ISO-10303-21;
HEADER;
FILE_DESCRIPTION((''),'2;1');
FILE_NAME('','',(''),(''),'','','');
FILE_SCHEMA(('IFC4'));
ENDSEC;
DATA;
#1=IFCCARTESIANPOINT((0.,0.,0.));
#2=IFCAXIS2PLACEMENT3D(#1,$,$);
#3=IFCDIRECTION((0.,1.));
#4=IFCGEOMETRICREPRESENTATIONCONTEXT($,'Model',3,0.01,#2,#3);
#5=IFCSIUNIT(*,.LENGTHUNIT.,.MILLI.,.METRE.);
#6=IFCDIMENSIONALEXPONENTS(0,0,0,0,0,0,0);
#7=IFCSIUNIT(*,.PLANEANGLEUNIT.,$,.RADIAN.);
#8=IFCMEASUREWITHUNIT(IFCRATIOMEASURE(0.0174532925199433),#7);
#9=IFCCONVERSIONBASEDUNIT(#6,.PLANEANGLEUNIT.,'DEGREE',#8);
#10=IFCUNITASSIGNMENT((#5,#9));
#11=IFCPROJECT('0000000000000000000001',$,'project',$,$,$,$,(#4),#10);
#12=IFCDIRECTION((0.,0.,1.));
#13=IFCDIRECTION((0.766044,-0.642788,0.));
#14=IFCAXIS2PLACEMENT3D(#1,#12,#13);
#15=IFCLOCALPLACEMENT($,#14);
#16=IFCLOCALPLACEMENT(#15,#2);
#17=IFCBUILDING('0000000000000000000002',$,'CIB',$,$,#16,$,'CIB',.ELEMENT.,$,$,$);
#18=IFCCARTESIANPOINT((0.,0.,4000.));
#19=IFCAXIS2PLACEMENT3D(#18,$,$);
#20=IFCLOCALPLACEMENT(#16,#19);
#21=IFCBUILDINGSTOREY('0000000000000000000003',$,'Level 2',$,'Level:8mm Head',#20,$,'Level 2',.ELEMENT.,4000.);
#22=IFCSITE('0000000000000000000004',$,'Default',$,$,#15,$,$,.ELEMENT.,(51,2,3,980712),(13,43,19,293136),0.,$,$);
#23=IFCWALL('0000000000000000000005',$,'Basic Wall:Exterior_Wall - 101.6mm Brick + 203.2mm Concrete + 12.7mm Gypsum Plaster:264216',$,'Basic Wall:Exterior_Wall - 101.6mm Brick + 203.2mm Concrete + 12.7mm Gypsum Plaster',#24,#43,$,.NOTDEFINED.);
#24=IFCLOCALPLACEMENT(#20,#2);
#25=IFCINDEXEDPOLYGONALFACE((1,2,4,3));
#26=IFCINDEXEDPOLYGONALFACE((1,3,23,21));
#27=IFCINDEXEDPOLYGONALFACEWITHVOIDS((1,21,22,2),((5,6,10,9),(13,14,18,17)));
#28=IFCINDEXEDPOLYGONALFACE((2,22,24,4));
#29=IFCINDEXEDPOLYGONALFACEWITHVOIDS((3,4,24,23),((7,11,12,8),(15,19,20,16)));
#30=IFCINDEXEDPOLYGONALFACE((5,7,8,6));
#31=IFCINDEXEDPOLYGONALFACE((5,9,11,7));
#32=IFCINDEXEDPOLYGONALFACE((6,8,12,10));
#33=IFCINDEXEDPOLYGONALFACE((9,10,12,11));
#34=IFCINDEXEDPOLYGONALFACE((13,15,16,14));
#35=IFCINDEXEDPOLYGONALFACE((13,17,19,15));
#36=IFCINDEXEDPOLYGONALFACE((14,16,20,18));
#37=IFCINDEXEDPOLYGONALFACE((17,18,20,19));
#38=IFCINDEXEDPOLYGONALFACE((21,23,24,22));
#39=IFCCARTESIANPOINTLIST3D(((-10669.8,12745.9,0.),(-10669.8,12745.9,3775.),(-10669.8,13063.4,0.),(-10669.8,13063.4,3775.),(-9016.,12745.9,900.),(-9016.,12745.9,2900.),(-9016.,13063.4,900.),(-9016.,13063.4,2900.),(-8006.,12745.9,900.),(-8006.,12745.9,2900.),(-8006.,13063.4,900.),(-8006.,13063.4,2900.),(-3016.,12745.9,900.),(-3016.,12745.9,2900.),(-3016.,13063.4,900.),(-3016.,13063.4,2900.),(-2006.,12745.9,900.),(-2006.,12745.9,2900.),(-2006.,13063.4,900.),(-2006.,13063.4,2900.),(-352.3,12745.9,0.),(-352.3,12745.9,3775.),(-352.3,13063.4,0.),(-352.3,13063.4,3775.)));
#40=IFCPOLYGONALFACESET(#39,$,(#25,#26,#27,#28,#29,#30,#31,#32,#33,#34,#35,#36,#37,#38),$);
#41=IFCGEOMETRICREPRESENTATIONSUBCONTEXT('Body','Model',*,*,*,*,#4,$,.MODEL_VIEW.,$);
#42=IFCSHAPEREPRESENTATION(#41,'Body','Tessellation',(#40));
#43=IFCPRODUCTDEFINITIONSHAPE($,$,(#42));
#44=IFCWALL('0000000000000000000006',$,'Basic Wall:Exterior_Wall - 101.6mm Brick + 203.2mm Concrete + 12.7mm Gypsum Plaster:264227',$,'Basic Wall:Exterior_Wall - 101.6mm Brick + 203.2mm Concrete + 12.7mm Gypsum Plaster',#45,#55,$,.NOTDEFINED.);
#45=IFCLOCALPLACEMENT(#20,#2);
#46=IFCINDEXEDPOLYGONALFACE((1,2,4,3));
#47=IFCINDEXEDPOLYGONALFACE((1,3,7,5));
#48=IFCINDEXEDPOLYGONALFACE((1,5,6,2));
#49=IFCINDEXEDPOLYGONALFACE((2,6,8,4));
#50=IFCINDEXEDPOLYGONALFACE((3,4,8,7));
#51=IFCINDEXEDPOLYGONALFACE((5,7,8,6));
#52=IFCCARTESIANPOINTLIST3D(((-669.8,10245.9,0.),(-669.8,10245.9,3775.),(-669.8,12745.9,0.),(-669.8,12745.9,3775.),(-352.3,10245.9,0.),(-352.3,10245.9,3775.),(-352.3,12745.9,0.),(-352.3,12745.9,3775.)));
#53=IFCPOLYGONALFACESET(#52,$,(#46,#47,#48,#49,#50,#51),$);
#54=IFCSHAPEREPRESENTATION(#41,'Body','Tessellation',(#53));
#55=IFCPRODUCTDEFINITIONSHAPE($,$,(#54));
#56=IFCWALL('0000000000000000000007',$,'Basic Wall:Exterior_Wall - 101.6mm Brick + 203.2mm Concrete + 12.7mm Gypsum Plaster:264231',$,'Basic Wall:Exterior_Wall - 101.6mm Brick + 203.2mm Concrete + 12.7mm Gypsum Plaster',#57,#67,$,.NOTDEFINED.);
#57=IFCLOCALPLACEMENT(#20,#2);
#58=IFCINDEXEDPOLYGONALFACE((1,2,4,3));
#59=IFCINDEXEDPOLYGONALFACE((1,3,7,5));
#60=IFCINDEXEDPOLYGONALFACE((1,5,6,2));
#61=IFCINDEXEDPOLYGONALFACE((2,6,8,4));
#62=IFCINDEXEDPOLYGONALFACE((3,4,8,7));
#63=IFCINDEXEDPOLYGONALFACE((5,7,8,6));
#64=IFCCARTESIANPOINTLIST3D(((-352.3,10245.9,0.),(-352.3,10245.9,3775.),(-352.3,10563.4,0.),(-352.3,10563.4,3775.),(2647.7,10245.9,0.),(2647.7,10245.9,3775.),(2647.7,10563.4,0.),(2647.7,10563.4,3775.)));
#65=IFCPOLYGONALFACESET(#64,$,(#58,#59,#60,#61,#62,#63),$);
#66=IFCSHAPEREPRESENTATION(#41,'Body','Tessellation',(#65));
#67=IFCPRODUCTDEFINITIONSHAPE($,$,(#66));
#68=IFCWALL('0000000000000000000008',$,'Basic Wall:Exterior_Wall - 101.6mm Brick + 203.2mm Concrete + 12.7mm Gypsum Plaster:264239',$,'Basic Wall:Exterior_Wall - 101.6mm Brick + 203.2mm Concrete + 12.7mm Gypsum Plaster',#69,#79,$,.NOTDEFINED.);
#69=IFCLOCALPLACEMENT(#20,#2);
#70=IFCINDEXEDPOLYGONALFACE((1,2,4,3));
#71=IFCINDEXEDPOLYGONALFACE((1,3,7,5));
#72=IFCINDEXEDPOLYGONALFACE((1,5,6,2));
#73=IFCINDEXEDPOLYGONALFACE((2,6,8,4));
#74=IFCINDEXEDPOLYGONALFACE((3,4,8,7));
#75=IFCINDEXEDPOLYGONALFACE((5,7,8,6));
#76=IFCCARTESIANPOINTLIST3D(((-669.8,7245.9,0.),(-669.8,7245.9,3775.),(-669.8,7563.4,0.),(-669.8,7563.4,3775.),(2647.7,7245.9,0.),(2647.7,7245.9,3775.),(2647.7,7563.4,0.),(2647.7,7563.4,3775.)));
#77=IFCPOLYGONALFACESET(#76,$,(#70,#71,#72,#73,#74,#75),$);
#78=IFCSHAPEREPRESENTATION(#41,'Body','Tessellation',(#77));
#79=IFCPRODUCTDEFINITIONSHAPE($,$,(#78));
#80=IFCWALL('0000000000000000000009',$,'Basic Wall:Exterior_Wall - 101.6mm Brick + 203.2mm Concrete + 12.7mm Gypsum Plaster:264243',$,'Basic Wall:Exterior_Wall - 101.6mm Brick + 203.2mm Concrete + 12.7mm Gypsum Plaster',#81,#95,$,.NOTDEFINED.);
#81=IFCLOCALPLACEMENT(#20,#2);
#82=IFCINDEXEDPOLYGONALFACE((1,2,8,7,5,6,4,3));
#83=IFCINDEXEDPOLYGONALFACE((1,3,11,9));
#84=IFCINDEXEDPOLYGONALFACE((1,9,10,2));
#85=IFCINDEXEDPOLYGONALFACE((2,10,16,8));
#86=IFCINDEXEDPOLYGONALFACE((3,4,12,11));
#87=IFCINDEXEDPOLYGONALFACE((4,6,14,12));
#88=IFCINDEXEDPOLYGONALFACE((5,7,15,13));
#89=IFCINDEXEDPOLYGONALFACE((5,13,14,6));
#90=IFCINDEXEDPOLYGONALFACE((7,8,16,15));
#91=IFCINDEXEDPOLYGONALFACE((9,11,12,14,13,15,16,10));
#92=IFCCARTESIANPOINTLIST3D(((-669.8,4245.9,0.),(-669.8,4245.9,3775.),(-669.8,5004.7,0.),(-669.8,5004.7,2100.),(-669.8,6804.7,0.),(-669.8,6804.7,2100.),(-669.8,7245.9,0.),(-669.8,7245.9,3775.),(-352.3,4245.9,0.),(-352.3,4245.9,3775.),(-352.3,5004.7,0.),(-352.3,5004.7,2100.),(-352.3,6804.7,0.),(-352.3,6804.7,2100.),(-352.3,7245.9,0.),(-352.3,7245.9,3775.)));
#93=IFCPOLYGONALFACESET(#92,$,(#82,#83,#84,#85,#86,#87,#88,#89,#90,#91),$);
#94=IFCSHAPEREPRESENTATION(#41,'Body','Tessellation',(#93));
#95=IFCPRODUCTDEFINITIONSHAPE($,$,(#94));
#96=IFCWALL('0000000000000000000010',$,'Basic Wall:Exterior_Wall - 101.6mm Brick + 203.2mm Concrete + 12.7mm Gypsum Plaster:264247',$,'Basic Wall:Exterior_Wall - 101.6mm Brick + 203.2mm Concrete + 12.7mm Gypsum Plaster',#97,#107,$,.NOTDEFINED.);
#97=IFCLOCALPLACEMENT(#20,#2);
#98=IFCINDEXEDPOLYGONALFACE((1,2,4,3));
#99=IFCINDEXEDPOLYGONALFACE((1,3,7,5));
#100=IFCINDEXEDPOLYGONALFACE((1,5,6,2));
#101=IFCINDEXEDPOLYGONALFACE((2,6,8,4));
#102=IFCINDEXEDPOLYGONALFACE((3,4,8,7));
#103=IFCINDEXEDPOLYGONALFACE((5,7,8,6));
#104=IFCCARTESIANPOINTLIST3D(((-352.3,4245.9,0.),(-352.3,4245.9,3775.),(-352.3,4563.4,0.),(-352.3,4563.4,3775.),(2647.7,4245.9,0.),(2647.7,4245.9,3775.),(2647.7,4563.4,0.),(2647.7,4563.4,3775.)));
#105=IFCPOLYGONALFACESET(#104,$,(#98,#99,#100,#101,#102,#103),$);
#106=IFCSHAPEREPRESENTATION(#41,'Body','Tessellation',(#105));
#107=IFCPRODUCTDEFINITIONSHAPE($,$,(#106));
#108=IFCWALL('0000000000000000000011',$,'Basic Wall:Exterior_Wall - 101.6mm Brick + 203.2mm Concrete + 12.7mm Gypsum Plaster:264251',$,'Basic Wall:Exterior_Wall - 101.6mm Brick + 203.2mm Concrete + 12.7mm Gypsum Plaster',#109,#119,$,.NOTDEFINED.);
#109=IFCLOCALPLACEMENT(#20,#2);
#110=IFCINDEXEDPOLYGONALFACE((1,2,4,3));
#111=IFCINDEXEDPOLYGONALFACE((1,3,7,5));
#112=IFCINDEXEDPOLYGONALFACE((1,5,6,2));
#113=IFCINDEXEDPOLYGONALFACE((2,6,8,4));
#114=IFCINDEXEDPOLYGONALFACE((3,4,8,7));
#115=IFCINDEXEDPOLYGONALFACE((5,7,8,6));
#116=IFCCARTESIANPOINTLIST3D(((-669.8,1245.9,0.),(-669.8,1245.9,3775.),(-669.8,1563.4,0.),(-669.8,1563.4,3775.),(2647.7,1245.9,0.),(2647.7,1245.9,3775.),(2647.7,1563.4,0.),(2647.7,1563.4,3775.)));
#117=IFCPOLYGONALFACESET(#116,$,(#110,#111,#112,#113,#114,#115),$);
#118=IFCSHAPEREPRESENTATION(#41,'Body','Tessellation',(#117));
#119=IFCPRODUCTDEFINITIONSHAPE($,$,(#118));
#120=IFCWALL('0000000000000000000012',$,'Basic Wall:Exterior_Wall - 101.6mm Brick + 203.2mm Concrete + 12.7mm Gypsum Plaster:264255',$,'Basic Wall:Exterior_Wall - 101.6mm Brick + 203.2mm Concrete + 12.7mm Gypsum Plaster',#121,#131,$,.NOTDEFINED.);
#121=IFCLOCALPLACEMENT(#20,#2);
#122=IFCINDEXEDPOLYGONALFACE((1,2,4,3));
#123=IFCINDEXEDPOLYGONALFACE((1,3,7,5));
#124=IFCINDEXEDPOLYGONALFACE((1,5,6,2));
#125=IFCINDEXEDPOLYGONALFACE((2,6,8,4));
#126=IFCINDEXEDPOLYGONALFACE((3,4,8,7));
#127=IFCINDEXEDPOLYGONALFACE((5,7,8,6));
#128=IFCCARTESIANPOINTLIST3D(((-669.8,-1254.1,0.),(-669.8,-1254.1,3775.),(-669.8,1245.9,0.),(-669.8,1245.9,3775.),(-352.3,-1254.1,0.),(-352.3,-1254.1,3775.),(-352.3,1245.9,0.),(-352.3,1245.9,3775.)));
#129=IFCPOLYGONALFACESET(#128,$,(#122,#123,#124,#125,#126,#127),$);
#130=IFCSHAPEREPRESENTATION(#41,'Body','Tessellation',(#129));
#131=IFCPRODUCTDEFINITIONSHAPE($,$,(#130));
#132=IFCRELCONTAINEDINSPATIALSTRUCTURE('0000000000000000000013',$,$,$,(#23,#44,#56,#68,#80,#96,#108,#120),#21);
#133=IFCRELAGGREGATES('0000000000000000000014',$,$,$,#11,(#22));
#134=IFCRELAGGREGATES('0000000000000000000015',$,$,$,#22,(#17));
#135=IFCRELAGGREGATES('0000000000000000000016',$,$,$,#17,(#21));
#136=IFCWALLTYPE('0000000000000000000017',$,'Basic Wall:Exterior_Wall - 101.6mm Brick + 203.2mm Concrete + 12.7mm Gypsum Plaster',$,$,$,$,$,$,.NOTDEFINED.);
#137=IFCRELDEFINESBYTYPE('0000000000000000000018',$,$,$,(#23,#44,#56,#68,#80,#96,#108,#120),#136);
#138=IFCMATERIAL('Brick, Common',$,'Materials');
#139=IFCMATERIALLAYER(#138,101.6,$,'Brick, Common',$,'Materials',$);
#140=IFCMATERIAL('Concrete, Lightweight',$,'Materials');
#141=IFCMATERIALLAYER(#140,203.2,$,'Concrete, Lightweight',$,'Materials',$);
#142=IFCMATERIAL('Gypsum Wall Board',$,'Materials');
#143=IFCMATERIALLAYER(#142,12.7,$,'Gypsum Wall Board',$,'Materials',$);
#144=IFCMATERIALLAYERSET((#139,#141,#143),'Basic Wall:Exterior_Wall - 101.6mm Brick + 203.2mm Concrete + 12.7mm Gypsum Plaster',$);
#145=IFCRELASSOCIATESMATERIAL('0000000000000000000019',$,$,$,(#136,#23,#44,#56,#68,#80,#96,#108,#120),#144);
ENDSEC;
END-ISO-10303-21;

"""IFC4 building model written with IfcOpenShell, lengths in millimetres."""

from ifc_helpers import new_model, entity, si_unit, converted_unit, direction, frame, frame_2d, origin, place, context, subcontext, project, spatial, polyline, rectangle, extrude, clip, bounded_halfspace, material, layer, layer_set, layer_usage, type_object, element, save


model = new_model("IFC4")

# Units and contexts
model_context = context("Model", 3, precision=0.01, world=origin(), true_north=direction((0.0, 1.0)))
body_context = subcontext(model_context, "Body", "Model", "MODEL_VIEW")
ifc_project = project(units=[si_unit("LENGTHUNIT", "METRE", prefix="MILLI"), converted_unit("PLANEANGLEUNIT", "DEGREE", entity("IfcRatioMeasure", 0.0174532925199433), si_unit("PLANEANGLEUNIT", "RADIAN"), dimensions=[0, 0, 0, 0, 0, 0, 0])], contexts=[model_context])

# Site, building, storey
site_placement = place(None, frame((0.0, 0.0, 0.0), z_axis=(0.0, 0.0, 1.0), x_axis=(0.766044, -0.642788, 0.0)))
site = spatial("IfcSite", under=ifc_project, at=site_placement, Name="Default", CompositionType="ELEMENT", RefLatitude=(51, 2, 3, 980712), RefLongitude=(13, 43, 19, 293136), RefElevation=0.0)
building_placement = place(site_placement, origin())
building = spatial("IfcBuilding", under=site, at=building_placement, Name="CIB", LongName="CIB", CompositionType="ELEMENT")
storey_placement = place(building_placement, frame((0.0, 0.0, 4000.0)))
storey = spatial("IfcBuildingStorey", under=building, at=storey_placement, Name="Level 2", ObjectType="Level:8mm Head", LongName="Level 2", CompositionType="ELEMENT", Elevation=4000.0)

# Wall, openings
ifc_material_1 = material(Name="Brick, Common", Category="Materials")
ifc_layer_1 = layer(ifc_material_1, 101.6, Name="Brick, Common", Category="Materials")
ifc_material_2 = material(Name="Concrete, Lightweight", Category="Materials")
ifc_layer_2 = layer(ifc_material_2, 203.2, Name="Concrete, Lightweight", Category="Materials")
ifc_material_3 = material(Name="Gypsum Wall Board", Category="Materials")
ifc_layer_3 = layer(ifc_material_3, 12.7, Name="Gypsum Wall Board", Category="Materials")
ifc_layer_set_1 = layer_set([ifc_layer_1, ifc_layer_2, ifc_layer_3], Name="Basic Wall:Exterior_Wall - 101.6mm Brick + 203.2mm Concrete + 12.7mm Gypsum Plaster")
ifc_layer_usage_1 = layer_usage(ifc_layer_set_1, "AXIS2", "POSITIVE", -158.8)
wall_type_1 = type_object("IfcWallType", Name="Basic Wall:Exterior_Wall - 101.6mm Brick + 203.2mm Concrete + 12.7mm Gypsum Plaster", PredefinedType="NOTDEFINED", material=ifc_layer_set_1)
wall_1_placement = place(storey_placement, frame((-352.3, 12904.7, 0.0), z_axis=(0.0, 0.0, 1.0), x_axis=(-1.0, 0.0, 0.0)))
wall_1 = element("IfcWall", 1, at=wall_1_placement, inside=storey, type_object=wall_type_1, material=ifc_layer_usage_1, Name="Basic Wall:Exterior_Wall - 101.6mm Brick + 203.2mm Concrete + 12.7mm Gypsum Plaster:264216", ObjectType="Basic Wall:Exterior_Wall - 101.6mm Brick + 203.2mm Concrete + 12.7mm Gypsum Plaster", PredefinedType="NOTDEFINED", context=body_context, shape_type="Clipping", body=[
    clip(extrude(rectangle(XDim=10317.5, YDim=317.5, at=frame_2d((5158.7, 0.0), x_axis=(-1.0, 0.0))), origin(), (0.0, 0.0, 1.0), 3775.0), bounded_halfspace(frame((0.0, -158.7, 3775.0), z_axis=(0.0, 0.0, -1.0), x_axis=(0.0, -1.0, 0.0)), True, frame((0.0, -158.7, 3775.0)), polyline([(0.0, 0.0), (10317.5, 0.0), (10317.5, 317.5), (10000.0, 317.5), (317.5, 317.5), (0.0, 317.5), (0.0, 0.0)]))),
])
opening_1_placement = place(wall_1_placement, frame((1653.7, -158.7, 900.0)))
element("IfcOpeningElement", 2, at=opening_1_placement, cuts=wall_1, ObjectType="Opening", PredefinedType="OPENING", context=body_context, shape_type="SweptSolid", body=[
    extrude(rectangle(XDim=2000.0, YDim=1010.0, at=frame_2d((1000.0, 505.0), x_axis=(1.0, 0.0))), frame((0.0, 0.0, 0.0), z_axis=(0.0, 1.0, 0.0), x_axis=(0.0, 0.0, 1.0)), (0.0, 0.0, 1.0), 317.5),
])
opening_2_placement = place(wall_1_placement, frame((7653.7, -158.7, 900.0)))
element("IfcOpeningElement", 3, at=opening_2_placement, cuts=wall_1, ObjectType="Opening", PredefinedType="OPENING", context=body_context, shape_type="SweptSolid", body=[
    extrude(rectangle(XDim=2000.0, YDim=1010.0, at=frame_2d((1000.0, 505.0), x_axis=(1.0, 0.0))), frame((0.0, 0.0, 0.0), z_axis=(0.0, 1.0, 0.0), x_axis=(0.0, 0.0, 1.0)), (0.0, 0.0, 1.0), 317.5),
])

# Walls
ifc_layer_usage_2 = layer_usage(ifc_layer_set_1, "AXIS2", "NEGATIVE", 158.8)
wall_2_placement = place(storey_placement, frame((-511.0, 12745.9, 0.0), z_axis=(0.0, 0.0, 1.0), x_axis=(0.0, -1.0, 0.0)))
element("IfcWall", 4, at=wall_2_placement, inside=storey, type_object=wall_type_1, material=ifc_layer_usage_2, Name="Basic Wall:Exterior_Wall - 101.6mm Brick + 203.2mm Concrete + 12.7mm Gypsum Plaster:264227", ObjectType="Basic Wall:Exterior_Wall - 101.6mm Brick + 203.2mm Concrete + 12.7mm Gypsum Plaster", PredefinedType="NOTDEFINED", context=body_context, shape_type="Clipping", body=[
    clip(extrude(rectangle(XDim=2500.0, YDim=317.5, at=frame_2d((1250.0, 0.0), x_axis=(-1.0, 0.0))), origin(), (0.0, 0.0, 1.0), 3775.0), bounded_halfspace(frame((0.0, -158.8, 3775.0), z_axis=(0.0, 0.0, -1.0), x_axis=(-1.0, 0.0, 0.0)), True, frame((0.0, -158.8, 3775.0)), polyline([(0.0, 0.0), (2500.0, 0.0), (2500.0, 317.5), (2182.5, 317.5), (0.0, 317.5), (0.0, 0.0)]))),
])
ifc_layer_usage_3 = layer_usage(ifc_layer_set_1, "AXIS2", "NEGATIVE", 158.8)
wall_3_placement = place(storey_placement, frame((-352.3, 10404.7, 0.0)))
element("IfcWall", 5, at=wall_3_placement, inside=storey, type_object=wall_type_1, material=ifc_layer_usage_3, Name="Basic Wall:Exterior_Wall - 101.6mm Brick + 203.2mm Concrete + 12.7mm Gypsum Plaster:264231", ObjectType="Basic Wall:Exterior_Wall - 101.6mm Brick + 203.2mm Concrete + 12.7mm Gypsum Plaster", PredefinedType="NOTDEFINED", context=body_context, shape_type="Clipping", body=[
    clip(extrude(rectangle(XDim=3000.0, YDim=317.5, at=frame_2d((1500.0, 0.0), x_axis=(-1.0, 0.0))), origin(), (0.0, 0.0, 1.0), 3775.0), bounded_halfspace(frame((0.0, -158.7, 3775.0), z_axis=(0.0, 0.0, -1.0), x_axis=(0.0, 1.0, 0.0)), True, frame((0.0, -158.7, 3775.0)), polyline([(0.0, 0.0), (2682.5, 0.0), (3000.0, 0.0), (3000.0, 317.5), (0.0, 317.5), (0.0, 0.0)]))),
])
ifc_layer_usage_4 = layer_usage(ifc_layer_set_1, "AXIS2", "POSITIVE", -158.8)
wall_4_placement = place(storey_placement, frame((-669.8, 7404.7, 0.0)))
element("IfcWall", 6, at=wall_4_placement, inside=storey, type_object=wall_type_1, material=ifc_layer_usage_4, Name="Basic Wall:Exterior_Wall - 101.6mm Brick + 203.2mm Concrete + 12.7mm Gypsum Plaster:264239", ObjectType="Basic Wall:Exterior_Wall - 101.6mm Brick + 203.2mm Concrete + 12.7mm Gypsum Plaster", PredefinedType="NOTDEFINED", context=body_context, shape_type="Clipping", body=[
    clip(extrude(rectangle(XDim=3317.5, YDim=317.5, at=frame_2d((1658.8, 0.0), x_axis=(-1.0, 0.0))), origin(), (0.0, 0.0, 1.0), 3775.0), bounded_halfspace(frame((0.0, -158.8, 3775.0), z_axis=(0.0, 0.0, -1.0), x_axis=(0.0, 1.0, 0.0)), True, frame((0.0, -158.8, 3775.0)), polyline([(0.0, 0.0), (317.5, 0.0), (3317.5, 0.0), (3317.5, 317.5), (3000.0, 317.5), (0.0, 317.5), (0.0, 0.0)]))),
])

# Wall, opening
ifc_layer_usage_5 = layer_usage(ifc_layer_set_1, "AXIS2", "POSITIVE", -158.8)
wall_5_placement = place(storey_placement, frame((-511.0, 4245.9, 0.0), z_axis=(0.0, 0.0, 1.0), x_axis=(0.0, 1.0, 0.0)))
wall_5 = element("IfcWall", 7, at=wall_5_placement, inside=storey, type_object=wall_type_1, material=ifc_layer_usage_5, Name="Basic Wall:Exterior_Wall - 101.6mm Brick + 203.2mm Concrete + 12.7mm Gypsum Plaster:264243", ObjectType="Basic Wall:Exterior_Wall - 101.6mm Brick + 203.2mm Concrete + 12.7mm Gypsum Plaster", PredefinedType="NOTDEFINED", context=body_context, shape_type="Clipping", body=[
    clip(extrude(rectangle(XDim=3000.0, YDim=317.5, at=frame_2d((1500.0, 0.0), x_axis=(-1.0, 0.0))), origin(), (0.0, 0.0, 1.0), 3775.0), bounded_halfspace(frame((3000.0, 158.8, 3775.0), z_axis=(0.0, 0.0, -1.0), x_axis=(1.0, 0.0, 0.0)), True, frame((3000.0, 158.8, 3775.0)), polyline([(0.0, 0.0), (-3000.0, 0.0), (-3000.0, -317.5), (-2682.5, -317.5), (0.0, -317.5), (0.0, 0.0)]))),
])
opening_3_placement = place(wall_5_placement, frame((758.7, -158.8, 0.0)))
element("IfcOpeningElement", 8, at=opening_3_placement, cuts=wall_5, ObjectType="Opening", PredefinedType="OPENING", context=body_context, shape_type="SweptSolid", body=[
    extrude(rectangle(XDim=2100.0, YDim=1800.0, at=frame_2d((1050.0, 900.0), x_axis=(1.0, 0.0))), frame((0.0, 0.0, 0.0), z_axis=(0.0, 1.0, 0.0), x_axis=(0.0, 0.0, 1.0)), (0.0, 0.0, 1.0), 317.5),
])

# Walls
ifc_layer_usage_6 = layer_usage(ifc_layer_set_1, "AXIS2", "POSITIVE", -158.8)
wall_6_placement = place(storey_placement, frame((2647.7, 4404.7, 0.0), z_axis=(0.0, 0.0, 1.0), x_axis=(-1.0, 0.0, 0.0)))
element("IfcWall", 9, at=wall_6_placement, inside=storey, type_object=wall_type_1, material=ifc_layer_usage_6, Name="Basic Wall:Exterior_Wall - 101.6mm Brick + 203.2mm Concrete + 12.7mm Gypsum Plaster:264247", ObjectType="Basic Wall:Exterior_Wall - 101.6mm Brick + 203.2mm Concrete + 12.7mm Gypsum Plaster", PredefinedType="NOTDEFINED", context=body_context, shape_type="Clipping", body=[
    clip(extrude(rectangle(XDim=3000.0, YDim=317.5, at=frame_2d((1500.0, 0.0), x_axis=(-1.0, 0.0))), origin(), (0.0, 0.0, 1.0), 3775.0), bounded_halfspace(frame((0.0, -158.8, 3775.0), z_axis=(0.0, 0.0, -1.0), x_axis=(0.0, -1.0, 0.0)), True, frame((0.0, -158.8, 3775.0)), polyline([(0.0, 0.0), (3000.0, 0.0), (3000.0, 317.5), (317.5, 317.5), (0.0, 317.5), (0.0, 0.0)]))),
])
ifc_layer_usage_7 = layer_usage(ifc_layer_set_1, "AXIS2", "NEGATIVE", 158.8)
wall_7_placement = place(storey_placement, frame((2647.7, 1404.7, 0.0), z_axis=(0.0, 0.0, 1.0), x_axis=(-1.0, 0.0, 0.0)))
element("IfcWall", 10, at=wall_7_placement, inside=storey, type_object=wall_type_1, material=ifc_layer_usage_7, Name="Basic Wall:Exterior_Wall - 101.6mm Brick + 203.2mm Concrete + 12.7mm Gypsum Plaster:264251", ObjectType="Basic Wall:Exterior_Wall - 101.6mm Brick + 203.2mm Concrete + 12.7mm Gypsum Plaster", PredefinedType="NOTDEFINED", context=body_context, shape_type="Clipping", body=[
    clip(extrude(rectangle(XDim=3317.5, YDim=317.5, at=frame_2d((1658.7, 0.0), x_axis=(-1.0, 0.0))), origin(), (0.0, 0.0, 1.0), 3775.0), bounded_halfspace(frame((0.0, -158.8, 3775.0), z_axis=(0.0, 0.0, -1.0), x_axis=(0.0, -1.0, 0.0)), True, frame((0.0, -158.8, 3775.0)), polyline([(0.0, 0.0), (317.5, 0.0), (3317.5, 0.0), (3317.5, 317.5), (3000.0, 317.5), (0.0, 317.5), (0.0, 0.0)]))),
])
ifc_layer_usage_8 = layer_usage(ifc_layer_set_1, "AXIS2", "NEGATIVE", 158.8)
wall_8_placement = place(storey_placement, frame((-511.0, 1245.9, 0.0), z_axis=(0.0, 0.0, 1.0), x_axis=(0.0, -1.0, 0.0)))
element("IfcWall", 11, at=wall_8_placement, inside=storey, type_object=wall_type_1, material=ifc_layer_usage_8, Name="Basic Wall:Exterior_Wall - 101.6mm Brick + 203.2mm Concrete + 12.7mm Gypsum Plaster:264255", ObjectType="Basic Wall:Exterior_Wall - 101.6mm Brick + 203.2mm Concrete + 12.7mm Gypsum Plaster", PredefinedType="NOTDEFINED", context=body_context, shape_type="Clipping", body=[
    clip(extrude(rectangle(XDim=2500.0, YDim=317.5, at=frame_2d((1250.0, 0.0), x_axis=(-1.0, 0.0))), origin(), (0.0, 0.0, 1.0), 3775.0), bounded_halfspace(frame((0.0, -158.8, 3775.0), z_axis=(0.0, 0.0, -1.0), x_axis=(-1.0, 0.0, 0.0)), True, frame((0.0, -158.8, 3775.0)), polyline([(0.0, 0.0), (2182.5, 0.0), (2500.0, 0.0), (2500.0, 317.5), (0.0, 317.5), (0.0, 0.0)]))),
])

save(model, "model.ifc")
